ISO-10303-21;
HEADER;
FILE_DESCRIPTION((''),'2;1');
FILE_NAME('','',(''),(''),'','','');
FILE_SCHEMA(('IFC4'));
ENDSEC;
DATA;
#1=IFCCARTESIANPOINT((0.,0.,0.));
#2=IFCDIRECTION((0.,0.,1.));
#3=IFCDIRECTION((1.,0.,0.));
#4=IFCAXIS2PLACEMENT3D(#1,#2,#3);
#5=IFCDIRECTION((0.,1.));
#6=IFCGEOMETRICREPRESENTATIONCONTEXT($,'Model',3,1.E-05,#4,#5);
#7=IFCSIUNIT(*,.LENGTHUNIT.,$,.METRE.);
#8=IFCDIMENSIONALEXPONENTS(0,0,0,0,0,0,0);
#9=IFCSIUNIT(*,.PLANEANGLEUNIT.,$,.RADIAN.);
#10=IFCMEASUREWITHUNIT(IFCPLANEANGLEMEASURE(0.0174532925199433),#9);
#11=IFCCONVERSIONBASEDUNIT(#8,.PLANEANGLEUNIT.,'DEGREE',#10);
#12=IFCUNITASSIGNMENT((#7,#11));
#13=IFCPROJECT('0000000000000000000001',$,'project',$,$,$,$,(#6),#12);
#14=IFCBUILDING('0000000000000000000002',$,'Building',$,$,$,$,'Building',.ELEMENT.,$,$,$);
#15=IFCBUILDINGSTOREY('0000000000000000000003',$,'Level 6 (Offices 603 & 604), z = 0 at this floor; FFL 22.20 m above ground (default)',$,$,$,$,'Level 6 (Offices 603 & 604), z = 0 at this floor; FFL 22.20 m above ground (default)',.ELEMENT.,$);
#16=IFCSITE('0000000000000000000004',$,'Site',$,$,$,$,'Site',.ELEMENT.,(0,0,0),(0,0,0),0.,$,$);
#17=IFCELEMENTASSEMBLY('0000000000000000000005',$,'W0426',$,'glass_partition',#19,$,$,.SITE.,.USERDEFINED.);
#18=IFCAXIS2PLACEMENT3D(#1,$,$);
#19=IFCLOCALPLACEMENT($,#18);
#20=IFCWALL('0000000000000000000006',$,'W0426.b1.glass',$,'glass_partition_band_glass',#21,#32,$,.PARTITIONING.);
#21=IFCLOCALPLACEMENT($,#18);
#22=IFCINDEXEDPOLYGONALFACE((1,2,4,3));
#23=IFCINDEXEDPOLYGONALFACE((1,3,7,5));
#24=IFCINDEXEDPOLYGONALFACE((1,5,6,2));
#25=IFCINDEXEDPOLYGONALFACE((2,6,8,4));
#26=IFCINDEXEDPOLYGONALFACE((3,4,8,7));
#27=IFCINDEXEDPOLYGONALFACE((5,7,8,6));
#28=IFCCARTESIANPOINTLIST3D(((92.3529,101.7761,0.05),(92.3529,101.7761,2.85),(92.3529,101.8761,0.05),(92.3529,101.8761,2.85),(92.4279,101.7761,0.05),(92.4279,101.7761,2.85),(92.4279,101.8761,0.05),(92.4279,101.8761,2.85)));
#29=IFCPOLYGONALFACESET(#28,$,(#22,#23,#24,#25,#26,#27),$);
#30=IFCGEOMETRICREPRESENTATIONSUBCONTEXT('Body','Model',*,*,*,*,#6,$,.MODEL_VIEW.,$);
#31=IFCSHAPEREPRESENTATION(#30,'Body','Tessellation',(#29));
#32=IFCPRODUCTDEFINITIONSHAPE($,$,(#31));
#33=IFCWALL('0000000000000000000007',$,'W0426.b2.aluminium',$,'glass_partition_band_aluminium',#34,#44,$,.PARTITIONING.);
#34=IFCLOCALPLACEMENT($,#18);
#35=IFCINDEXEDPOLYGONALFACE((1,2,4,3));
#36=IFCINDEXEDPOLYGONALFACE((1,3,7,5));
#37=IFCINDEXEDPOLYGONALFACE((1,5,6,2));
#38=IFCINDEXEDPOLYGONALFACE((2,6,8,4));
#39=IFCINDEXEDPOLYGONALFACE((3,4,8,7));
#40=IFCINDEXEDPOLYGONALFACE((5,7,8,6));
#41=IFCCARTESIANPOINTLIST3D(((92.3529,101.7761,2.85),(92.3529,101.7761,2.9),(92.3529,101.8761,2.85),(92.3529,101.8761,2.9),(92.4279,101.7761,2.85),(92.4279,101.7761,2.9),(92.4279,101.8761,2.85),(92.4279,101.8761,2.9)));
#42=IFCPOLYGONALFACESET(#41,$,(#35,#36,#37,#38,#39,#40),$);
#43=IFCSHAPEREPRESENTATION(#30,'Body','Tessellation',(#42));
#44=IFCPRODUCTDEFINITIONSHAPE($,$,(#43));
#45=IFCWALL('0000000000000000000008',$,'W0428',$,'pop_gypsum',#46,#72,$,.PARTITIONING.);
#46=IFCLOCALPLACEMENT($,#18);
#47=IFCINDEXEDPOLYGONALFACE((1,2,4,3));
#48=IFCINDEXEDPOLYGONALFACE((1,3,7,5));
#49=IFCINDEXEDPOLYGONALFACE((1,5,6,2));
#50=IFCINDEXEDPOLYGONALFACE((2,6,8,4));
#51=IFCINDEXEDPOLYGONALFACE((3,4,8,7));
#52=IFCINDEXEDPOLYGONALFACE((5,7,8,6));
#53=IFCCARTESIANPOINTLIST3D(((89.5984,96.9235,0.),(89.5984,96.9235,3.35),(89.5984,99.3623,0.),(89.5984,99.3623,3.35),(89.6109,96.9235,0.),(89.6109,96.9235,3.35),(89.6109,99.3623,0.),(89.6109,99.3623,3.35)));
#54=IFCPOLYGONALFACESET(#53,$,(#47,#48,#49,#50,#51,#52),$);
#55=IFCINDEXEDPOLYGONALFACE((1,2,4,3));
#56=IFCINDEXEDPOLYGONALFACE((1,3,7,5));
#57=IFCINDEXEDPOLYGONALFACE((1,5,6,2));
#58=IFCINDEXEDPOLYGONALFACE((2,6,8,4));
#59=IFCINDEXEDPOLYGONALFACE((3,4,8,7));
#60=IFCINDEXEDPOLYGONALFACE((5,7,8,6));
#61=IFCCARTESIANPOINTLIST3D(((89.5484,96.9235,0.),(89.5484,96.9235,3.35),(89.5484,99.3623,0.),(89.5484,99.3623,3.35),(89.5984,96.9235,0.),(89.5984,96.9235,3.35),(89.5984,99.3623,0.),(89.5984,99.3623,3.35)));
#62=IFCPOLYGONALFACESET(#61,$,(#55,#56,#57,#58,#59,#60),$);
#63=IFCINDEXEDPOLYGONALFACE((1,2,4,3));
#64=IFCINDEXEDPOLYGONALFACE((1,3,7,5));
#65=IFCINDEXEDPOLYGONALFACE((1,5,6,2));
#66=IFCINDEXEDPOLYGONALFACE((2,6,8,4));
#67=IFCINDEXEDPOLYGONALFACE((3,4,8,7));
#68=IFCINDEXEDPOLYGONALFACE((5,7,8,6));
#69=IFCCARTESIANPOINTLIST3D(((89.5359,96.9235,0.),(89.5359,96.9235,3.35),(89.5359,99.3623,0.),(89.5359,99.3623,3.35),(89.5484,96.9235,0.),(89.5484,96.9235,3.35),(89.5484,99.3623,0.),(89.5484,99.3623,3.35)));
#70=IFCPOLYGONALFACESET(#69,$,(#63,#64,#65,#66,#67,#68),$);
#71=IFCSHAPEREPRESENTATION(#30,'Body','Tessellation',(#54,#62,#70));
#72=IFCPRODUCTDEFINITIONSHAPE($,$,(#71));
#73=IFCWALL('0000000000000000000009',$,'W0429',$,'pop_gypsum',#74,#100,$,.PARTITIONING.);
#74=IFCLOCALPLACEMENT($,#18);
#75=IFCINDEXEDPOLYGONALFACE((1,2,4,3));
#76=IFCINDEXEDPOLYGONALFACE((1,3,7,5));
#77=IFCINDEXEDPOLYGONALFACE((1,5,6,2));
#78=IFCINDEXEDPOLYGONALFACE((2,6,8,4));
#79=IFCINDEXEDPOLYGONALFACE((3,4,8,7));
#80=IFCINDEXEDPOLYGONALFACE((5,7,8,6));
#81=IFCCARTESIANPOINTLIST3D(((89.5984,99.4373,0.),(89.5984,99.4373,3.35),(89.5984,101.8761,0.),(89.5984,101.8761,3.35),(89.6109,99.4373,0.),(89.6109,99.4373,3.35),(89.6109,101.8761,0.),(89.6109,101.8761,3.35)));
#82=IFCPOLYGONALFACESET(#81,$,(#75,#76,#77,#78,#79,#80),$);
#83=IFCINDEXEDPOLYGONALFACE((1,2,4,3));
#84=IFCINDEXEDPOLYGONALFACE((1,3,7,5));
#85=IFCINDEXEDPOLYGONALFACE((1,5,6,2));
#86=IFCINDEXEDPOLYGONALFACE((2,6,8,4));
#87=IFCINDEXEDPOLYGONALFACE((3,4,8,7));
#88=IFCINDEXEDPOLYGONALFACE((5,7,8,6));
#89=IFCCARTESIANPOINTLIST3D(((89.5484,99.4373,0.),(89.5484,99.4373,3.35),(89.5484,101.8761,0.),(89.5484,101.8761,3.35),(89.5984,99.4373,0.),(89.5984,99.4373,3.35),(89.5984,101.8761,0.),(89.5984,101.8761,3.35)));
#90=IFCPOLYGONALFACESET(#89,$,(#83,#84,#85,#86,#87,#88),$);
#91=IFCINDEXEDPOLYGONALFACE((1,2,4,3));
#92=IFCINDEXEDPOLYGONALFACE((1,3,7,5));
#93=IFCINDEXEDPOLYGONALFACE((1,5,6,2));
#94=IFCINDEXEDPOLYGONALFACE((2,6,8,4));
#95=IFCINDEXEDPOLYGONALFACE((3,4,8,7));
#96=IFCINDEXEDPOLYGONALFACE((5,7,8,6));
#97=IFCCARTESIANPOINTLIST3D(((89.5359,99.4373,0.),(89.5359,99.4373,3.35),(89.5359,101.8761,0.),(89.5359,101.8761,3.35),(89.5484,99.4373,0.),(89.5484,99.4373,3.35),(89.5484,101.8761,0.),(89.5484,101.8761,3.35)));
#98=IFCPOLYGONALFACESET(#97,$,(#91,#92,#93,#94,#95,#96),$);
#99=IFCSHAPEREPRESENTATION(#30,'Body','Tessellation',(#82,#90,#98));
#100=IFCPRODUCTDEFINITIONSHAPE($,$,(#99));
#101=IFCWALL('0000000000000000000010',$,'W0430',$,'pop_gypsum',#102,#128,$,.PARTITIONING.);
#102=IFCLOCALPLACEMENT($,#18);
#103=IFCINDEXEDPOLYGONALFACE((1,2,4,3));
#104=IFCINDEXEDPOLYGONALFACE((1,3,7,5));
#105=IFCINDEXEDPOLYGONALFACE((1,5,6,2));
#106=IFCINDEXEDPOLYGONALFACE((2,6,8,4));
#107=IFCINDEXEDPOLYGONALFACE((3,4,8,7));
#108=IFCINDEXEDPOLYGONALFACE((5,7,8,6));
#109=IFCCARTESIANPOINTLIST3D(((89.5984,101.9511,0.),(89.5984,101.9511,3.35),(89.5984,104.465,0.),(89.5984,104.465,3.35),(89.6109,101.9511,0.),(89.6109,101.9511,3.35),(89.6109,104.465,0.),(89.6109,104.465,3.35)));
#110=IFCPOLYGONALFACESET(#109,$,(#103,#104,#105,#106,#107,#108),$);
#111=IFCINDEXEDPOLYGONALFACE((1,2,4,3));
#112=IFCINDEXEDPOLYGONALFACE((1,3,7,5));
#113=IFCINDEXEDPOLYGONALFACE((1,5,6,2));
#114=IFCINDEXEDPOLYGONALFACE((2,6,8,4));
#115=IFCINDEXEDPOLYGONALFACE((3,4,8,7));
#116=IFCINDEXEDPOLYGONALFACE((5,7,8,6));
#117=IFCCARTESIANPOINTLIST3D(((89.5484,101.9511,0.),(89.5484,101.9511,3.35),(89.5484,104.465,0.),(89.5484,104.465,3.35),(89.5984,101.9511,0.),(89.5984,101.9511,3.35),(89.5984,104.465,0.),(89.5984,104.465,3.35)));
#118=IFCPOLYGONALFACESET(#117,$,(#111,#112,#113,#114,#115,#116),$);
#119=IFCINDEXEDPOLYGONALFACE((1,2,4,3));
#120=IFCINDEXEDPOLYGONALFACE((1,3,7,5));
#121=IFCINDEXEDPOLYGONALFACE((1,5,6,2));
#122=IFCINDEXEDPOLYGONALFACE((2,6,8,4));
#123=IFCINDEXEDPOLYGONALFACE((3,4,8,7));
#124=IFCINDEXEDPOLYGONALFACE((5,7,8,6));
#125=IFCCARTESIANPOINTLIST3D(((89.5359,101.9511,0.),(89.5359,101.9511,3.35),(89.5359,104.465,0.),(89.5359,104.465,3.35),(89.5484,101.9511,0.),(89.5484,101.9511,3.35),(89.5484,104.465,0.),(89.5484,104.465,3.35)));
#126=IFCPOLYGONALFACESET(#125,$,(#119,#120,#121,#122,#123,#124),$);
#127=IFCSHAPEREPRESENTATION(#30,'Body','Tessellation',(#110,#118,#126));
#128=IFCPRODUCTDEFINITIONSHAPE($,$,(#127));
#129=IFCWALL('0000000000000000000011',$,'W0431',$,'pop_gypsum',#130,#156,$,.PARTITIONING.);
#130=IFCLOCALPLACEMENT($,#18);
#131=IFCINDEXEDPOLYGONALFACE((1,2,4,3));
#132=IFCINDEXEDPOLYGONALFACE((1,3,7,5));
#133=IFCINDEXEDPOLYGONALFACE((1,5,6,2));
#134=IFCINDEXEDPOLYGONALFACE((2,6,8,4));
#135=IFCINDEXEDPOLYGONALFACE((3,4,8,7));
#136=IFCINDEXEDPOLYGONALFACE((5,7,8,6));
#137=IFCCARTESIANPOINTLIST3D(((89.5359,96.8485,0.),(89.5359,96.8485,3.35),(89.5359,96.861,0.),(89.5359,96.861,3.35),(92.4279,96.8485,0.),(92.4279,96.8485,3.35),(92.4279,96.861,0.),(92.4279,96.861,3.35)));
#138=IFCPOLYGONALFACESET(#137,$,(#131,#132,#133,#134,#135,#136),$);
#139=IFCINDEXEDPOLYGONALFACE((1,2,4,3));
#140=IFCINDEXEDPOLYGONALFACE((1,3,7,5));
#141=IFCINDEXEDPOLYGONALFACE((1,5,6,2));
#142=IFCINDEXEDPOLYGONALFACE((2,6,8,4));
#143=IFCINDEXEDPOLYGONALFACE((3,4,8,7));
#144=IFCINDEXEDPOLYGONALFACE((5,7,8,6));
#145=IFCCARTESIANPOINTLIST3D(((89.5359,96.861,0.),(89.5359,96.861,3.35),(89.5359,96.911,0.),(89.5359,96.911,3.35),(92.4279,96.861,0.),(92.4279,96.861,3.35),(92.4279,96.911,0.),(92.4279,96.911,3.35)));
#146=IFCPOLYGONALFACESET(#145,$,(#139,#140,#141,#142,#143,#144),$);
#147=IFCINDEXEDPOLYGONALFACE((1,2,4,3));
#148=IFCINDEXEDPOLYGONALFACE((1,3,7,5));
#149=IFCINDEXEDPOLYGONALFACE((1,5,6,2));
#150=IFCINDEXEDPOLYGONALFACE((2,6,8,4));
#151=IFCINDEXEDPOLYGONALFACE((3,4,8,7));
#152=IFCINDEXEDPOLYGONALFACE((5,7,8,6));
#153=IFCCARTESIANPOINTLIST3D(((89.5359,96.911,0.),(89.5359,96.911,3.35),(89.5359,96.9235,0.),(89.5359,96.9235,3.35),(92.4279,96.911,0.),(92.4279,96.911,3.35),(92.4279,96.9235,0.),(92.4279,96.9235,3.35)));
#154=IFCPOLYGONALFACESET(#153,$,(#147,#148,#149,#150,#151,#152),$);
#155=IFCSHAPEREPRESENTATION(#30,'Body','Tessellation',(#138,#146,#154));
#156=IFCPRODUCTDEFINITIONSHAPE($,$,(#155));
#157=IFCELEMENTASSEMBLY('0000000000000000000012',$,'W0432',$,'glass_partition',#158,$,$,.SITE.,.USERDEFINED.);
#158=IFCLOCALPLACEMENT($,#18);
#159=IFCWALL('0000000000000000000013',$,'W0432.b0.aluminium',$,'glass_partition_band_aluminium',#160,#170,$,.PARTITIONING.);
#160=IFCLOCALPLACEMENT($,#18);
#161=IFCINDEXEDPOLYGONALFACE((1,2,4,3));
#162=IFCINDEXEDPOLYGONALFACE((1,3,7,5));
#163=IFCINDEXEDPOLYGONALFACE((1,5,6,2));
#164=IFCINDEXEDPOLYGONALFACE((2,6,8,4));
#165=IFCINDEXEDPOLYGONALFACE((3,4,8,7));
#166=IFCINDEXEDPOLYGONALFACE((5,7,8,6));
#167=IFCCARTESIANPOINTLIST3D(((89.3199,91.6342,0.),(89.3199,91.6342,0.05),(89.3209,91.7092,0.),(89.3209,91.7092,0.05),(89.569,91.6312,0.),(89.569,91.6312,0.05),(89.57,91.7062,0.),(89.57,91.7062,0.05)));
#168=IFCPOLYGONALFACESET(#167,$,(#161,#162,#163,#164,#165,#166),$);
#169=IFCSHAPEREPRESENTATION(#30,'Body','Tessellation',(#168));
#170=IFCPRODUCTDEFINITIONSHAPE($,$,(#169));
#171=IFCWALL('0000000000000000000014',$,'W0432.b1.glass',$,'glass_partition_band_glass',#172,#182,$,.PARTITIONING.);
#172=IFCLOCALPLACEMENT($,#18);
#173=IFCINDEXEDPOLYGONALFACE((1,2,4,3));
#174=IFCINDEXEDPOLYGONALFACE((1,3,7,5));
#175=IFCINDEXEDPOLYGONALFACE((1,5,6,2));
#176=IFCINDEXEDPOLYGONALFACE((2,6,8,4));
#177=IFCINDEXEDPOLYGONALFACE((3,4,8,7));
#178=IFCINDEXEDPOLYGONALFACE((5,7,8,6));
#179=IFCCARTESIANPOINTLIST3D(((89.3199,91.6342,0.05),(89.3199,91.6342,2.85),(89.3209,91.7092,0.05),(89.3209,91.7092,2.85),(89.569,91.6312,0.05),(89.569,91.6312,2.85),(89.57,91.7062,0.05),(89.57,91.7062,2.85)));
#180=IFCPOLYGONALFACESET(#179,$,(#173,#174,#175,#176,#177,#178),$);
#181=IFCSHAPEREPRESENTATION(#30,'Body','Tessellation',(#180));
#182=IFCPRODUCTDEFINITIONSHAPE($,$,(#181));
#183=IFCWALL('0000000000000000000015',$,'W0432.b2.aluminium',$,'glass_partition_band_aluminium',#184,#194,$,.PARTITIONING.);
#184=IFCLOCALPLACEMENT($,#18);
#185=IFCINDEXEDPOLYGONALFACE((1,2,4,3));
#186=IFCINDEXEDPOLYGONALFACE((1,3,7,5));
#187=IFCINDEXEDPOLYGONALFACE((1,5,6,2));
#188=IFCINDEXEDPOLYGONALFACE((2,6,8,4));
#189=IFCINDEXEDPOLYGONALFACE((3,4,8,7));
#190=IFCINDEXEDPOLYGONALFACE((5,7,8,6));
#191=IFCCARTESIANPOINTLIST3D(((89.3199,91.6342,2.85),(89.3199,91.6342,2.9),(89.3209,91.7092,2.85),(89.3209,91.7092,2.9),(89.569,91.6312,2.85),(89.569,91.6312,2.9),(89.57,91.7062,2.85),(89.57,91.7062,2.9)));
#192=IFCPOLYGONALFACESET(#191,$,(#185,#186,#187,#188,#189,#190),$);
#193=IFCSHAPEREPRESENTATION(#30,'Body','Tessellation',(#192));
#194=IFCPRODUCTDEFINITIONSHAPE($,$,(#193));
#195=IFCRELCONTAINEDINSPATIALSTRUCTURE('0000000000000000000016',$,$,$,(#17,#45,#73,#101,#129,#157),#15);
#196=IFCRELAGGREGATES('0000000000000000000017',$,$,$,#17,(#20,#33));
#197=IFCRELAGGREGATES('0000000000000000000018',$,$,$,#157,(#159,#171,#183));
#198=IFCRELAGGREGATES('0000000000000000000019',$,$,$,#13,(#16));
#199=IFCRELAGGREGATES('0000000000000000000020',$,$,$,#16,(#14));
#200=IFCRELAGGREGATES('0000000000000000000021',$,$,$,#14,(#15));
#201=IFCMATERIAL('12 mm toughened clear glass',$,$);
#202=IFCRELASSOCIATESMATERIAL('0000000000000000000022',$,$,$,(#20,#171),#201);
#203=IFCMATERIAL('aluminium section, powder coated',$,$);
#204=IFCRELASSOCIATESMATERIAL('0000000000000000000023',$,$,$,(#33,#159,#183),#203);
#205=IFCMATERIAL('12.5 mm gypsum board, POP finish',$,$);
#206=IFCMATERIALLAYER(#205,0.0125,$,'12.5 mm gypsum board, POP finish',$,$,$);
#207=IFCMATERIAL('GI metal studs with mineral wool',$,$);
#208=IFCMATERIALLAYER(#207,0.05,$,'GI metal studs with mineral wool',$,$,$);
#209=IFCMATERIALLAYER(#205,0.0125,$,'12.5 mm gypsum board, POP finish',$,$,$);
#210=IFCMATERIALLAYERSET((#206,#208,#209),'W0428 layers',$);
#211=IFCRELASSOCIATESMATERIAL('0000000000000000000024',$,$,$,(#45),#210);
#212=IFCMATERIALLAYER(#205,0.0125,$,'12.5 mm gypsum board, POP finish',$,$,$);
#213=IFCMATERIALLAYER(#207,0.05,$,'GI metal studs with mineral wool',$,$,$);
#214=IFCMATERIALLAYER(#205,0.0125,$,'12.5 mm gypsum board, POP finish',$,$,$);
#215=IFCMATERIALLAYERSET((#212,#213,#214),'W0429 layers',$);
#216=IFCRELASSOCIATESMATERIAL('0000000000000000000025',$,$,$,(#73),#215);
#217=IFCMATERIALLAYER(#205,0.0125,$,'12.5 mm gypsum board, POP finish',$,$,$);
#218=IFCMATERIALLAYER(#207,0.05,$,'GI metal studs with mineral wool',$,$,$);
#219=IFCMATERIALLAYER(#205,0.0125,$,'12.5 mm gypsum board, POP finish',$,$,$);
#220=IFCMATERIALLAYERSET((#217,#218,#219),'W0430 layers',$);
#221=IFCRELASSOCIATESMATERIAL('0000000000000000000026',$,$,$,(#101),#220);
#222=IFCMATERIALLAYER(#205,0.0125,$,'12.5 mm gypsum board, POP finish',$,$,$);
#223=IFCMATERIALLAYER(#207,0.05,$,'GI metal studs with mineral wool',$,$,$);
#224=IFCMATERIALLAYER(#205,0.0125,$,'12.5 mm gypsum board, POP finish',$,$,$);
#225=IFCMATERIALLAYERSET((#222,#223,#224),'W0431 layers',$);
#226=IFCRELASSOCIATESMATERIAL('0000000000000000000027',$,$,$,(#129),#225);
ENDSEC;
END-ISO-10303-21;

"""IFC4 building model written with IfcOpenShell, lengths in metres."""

from ifc_helpers import new_model, entity, si_unit, converted_unit, direction, frame, frame_2d, origin_with_axes, place, context, subcontext, project, spatial, rectangle, extrude, material, layer, layer_set, layer_usage, element, aggregate, save


model = new_model("IFC4")

# Units and contexts
model_context = context("Model", 3, precision=1e-05, world=origin_with_axes(), true_north=direction((0.0, 1.0)))
body_context = subcontext(model_context, "Body", "Model", "MODEL_VIEW")
ifc_project = project(units=[si_unit("LENGTHUNIT", "METRE"), converted_unit("PLANEANGLEUNIT", "DEGREE", entity("IfcPlaneAngleMeasure", 0.0174532925199433), si_unit("PLANEANGLEUNIT", "RADIAN"), dimensions=[0, 0, 0, 0, 0, 0, 0])], contexts=[model_context])

# Site, building, storey
site = spatial("IfcSite", under=ifc_project, Name="Site", LongName="Site", CompositionType="ELEMENT", RefLatitude=(0, 0, 0), RefLongitude=(0, 0, 0), RefElevation=0.0)
building = spatial("IfcBuilding", under=site, Name="Building", LongName="Building", CompositionType="ELEMENT")
storey = spatial("IfcBuildingStorey", under=building, Name="Level 6 (Offices 603 & 604), z = 0 at this floor; FFL 22.20 m above ground (default)", LongName="Level 6 (Offices 603 & 604), z = 0 at this floor; FFL 22.20 m above ground (default)", CompositionType="ELEMENT")

# Shared definitions
ifc_material_1 = material(Name="aluminium section, powder coated")
placement = place(None, origin_with_axes())

# Shared definitions
ifc_material_2 = material(Name="12.5 mm gypsum board, POP finish")
ifc_material_3 = material(Name="GI metal studs with mineral wool")

# Element assembly, walls
ifc_material_4 = material(Name="12 mm toughened clear glass")
assembly_1 = element("IfcElementAssembly", 1, inside=storey, Name="W0426", ObjectType="glass_partition", AssemblyPlace="SITE", PredefinedType="USERDEFINED")
wall_1 = element("IfcWall", 2, at=placement, material=ifc_material_4, Name="W0426.b1.glass", ObjectType="glass_partition_band_glass", PredefinedType="PARTITIONING", context=body_context, shape_type="SweptSolid", body=[
    extrude(rectangle(XDim=0.1, YDim=0.075, at=frame_2d((0.0, 0.0), x_axis=(0.0, 1.0))), frame((92.3904, 101.8261, 0.05), z_axis=(0.0, 0.0, 1.0), x_axis=(1.0, 0.0, 0.0)), (0.0, 0.0, 1.0), 2.8),
])
wall_2 = element("IfcWall", 3, at=placement, material=ifc_material_1, Name="W0426.b2.aluminium", ObjectType="glass_partition_band_aluminium", PredefinedType="PARTITIONING", context=body_context, shape_type="SweptSolid", body=[
    extrude(rectangle(XDim=0.1, YDim=0.075, at=frame_2d((0.0, 0.0), x_axis=(0.0, 1.0))), frame((92.3904, 101.8261, 2.85), z_axis=(0.0, 0.0, 1.0), x_axis=(1.0, 0.0, 0.0)), (0.0, 0.0, 1.0), 0.05),
])
aggregate(assembly_1, [wall_1, wall_2])

# Walls
ifc_layer_1 = layer(ifc_material_2, 0.0125, Name="12.5 mm gypsum board, POP finish")
ifc_layer_2 = layer(ifc_material_3, 0.05, Name="GI metal studs with mineral wool")
ifc_layer_3 = layer(ifc_material_2, 0.0125, Name="12.5 mm gypsum board, POP finish")
ifc_layer_set_1 = layer_set([ifc_layer_1, ifc_layer_2, ifc_layer_3], Name="W0428 layers")
ifc_layer_usage_1 = layer_usage(ifc_layer_set_1, "AXIS2", "POSITIVE", -0.0375)
element("IfcWall", 4, at=placement, inside=storey, material=ifc_layer_usage_1, Name="W0428", ObjectType="pop_gypsum", PredefinedType="PARTITIONING", context=body_context, shape_type="SweptSolid", body=[
    extrude(rectangle(XDim=2.4388, YDim=0.0125, at=frame_2d((0.0, 0.0), x_axis=(0.0, 1.0))), frame((89.6047, 98.1429, 0.0), z_axis=(0.0, 0.0, 1.0), x_axis=(1.0, 0.0, 0.0)), (0.0, 0.0, 1.0), 3.35),
    extrude(rectangle(XDim=2.4388, YDim=0.05, at=frame_2d((-0.0312, 0.0), x_axis=(0.0, 1.0))), frame((89.6047, 98.1429, 0.0), z_axis=(0.0, 0.0, 1.0), x_axis=(1.0, 0.0, 0.0)), (0.0, 0.0, 1.0), 3.35),
    extrude(rectangle(XDim=2.4388, YDim=0.0125, at=frame_2d((-0.0625, 0.0), x_axis=(0.0, 1.0))), frame((89.6047, 98.1429, 0.0), z_axis=(0.0, 0.0, 1.0), x_axis=(1.0, 0.0, 0.0)), (0.0, 0.0, 1.0), 3.35),
])
ifc_layer_4 = layer(ifc_material_2, 0.0125, Name="12.5 mm gypsum board, POP finish")
ifc_layer_5 = layer(ifc_material_3, 0.05, Name="GI metal studs with mineral wool")
ifc_layer_6 = layer(ifc_material_2, 0.0125, Name="12.5 mm gypsum board, POP finish")
ifc_layer_set_2 = layer_set([ifc_layer_4, ifc_layer_5, ifc_layer_6], Name="W0429 layers")
ifc_layer_usage_2 = layer_usage(ifc_layer_set_2, "AXIS2", "POSITIVE", -0.0375)
element("IfcWall", 5, at=placement, inside=storey, material=ifc_layer_usage_2, Name="W0429", ObjectType="pop_gypsum", PredefinedType="PARTITIONING", context=body_context, shape_type="SweptSolid", body=[
    extrude(rectangle(XDim=2.4388, YDim=0.0125, at=frame_2d((0.0, 0.0), x_axis=(0.0, 1.0))), frame((89.6047, 100.6567, 0.0), z_axis=(0.0, 0.0, 1.0), x_axis=(1.0, 0.0, 0.0)), (0.0, 0.0, 1.0), 3.35),
    extrude(rectangle(XDim=2.4388, YDim=0.05, at=frame_2d((-0.0312, 0.0), x_axis=(0.0, 1.0))), frame((89.6047, 100.6567, 0.0), z_axis=(0.0, 0.0, 1.0), x_axis=(1.0, 0.0, 0.0)), (0.0, 0.0, 1.0), 3.35),
    extrude(rectangle(XDim=2.4388, YDim=0.0125, at=frame_2d((-0.0625, 0.0), x_axis=(0.0, 1.0))), frame((89.6047, 100.6567, 0.0), z_axis=(0.0, 0.0, 1.0), x_axis=(1.0, 0.0, 0.0)), (0.0, 0.0, 1.0), 3.35),
])
ifc_layer_7 = layer(ifc_material_2, 0.0125, Name="12.5 mm gypsum board, POP finish")
ifc_layer_8 = layer(ifc_material_3, 0.05, Name="GI metal studs with mineral wool")
ifc_layer_9 = layer(ifc_material_2, 0.0125, Name="12.5 mm gypsum board, POP finish")
ifc_layer_set_3 = layer_set([ifc_layer_7, ifc_layer_8, ifc_layer_9], Name="W0430 layers")
ifc_layer_usage_3 = layer_usage(ifc_layer_set_3, "AXIS2", "POSITIVE", -0.0375)
element("IfcWall", 6, at=placement, inside=storey, material=ifc_layer_usage_3, Name="W0430", ObjectType="pop_gypsum", PredefinedType="PARTITIONING", context=body_context, shape_type="SweptSolid", body=[
    extrude(rectangle(XDim=2.5139, YDim=0.0125, at=frame_2d((0.0, 0.0), x_axis=(0.0, 1.0))), frame((89.6047, 103.2081, 0.0), z_axis=(0.0, 0.0, 1.0), x_axis=(1.0, 0.0, 0.0)), (0.0, 0.0, 1.0), 3.35),
    extrude(rectangle(XDim=2.5139, YDim=0.05, at=frame_2d((-0.0312, 0.0), x_axis=(0.0, 1.0))), frame((89.6047, 103.2081, 0.0), z_axis=(0.0, 0.0, 1.0), x_axis=(1.0, 0.0, 0.0)), (0.0, 0.0, 1.0), 3.35),
    extrude(rectangle(XDim=2.5139, YDim=0.0125, at=frame_2d((-0.0625, 0.0), x_axis=(0.0, 1.0))), frame((89.6047, 103.2081, 0.0), z_axis=(0.0, 0.0, 1.0), x_axis=(1.0, 0.0, 0.0)), (0.0, 0.0, 1.0), 3.35),
])
ifc_layer_10 = layer(ifc_material_2, 0.0125, Name="12.5 mm gypsum board, POP finish")
ifc_layer_11 = layer(ifc_material_3, 0.05, Name="GI metal studs with mineral wool")
ifc_layer_12 = layer(ifc_material_2, 0.0125, Name="12.5 mm gypsum board, POP finish")
ifc_layer_set_4 = layer_set([ifc_layer_10, ifc_layer_11, ifc_layer_12], Name="W0431 layers")
ifc_layer_usage_4 = layer_usage(ifc_layer_set_4, "AXIS2", "POSITIVE", -0.0375)
element("IfcWall", 7, at=placement, inside=storey, material=ifc_layer_usage_4, Name="W0431", ObjectType="pop_gypsum", PredefinedType="PARTITIONING", context=body_context, shape_type="SweptSolid", body=[
    extrude(rectangle(XDim=2.892, YDim=0.0125, at=frame_2d((0.0, 0.0), x_axis=(1.0, 0.0))), frame((90.9819, 96.8547, 0.0), z_axis=(0.0, 0.0, 1.0), x_axis=(1.0, 0.0, 0.0)), (0.0, 0.0, 1.0), 3.35),
    extrude(rectangle(XDim=2.892, YDim=0.05, at=frame_2d((0.0, 0.0313), x_axis=(1.0, 0.0))), frame((90.9819, 96.8547, 0.0), z_axis=(0.0, 0.0, 1.0), x_axis=(1.0, 0.0, 0.0)), (0.0, 0.0, 1.0), 3.35),
    extrude(rectangle(XDim=2.892, YDim=0.0125, at=frame_2d((0.0, 0.0625), x_axis=(1.0, 0.0))), frame((90.9819, 96.8547, 0.0), z_axis=(0.0, 0.0, 1.0), x_axis=(1.0, 0.0, 0.0)), (0.0, 0.0, 1.0), 3.35),
])

# Element assembly, walls
assembly_2 = element("IfcElementAssembly", 8, inside=storey, Name="W0432", ObjectType="glass_partition", AssemblyPlace="SITE", PredefinedType="USERDEFINED")
wall_3 = element("IfcWall", 9, at=placement, material=ifc_material_1, Name="W0432.b0.aluminium", ObjectType="glass_partition_band_aluminium", PredefinedType="PARTITIONING", context=body_context, shape_type="SweptSolid", body=[
    extrude(rectangle(XDim=0.2491, YDim=0.075, at=frame_2d((0.0, 0.0), x_axis=(0.999927, -0.012042))), frame((89.445, 91.6702, 0.0), z_axis=(0.0, 0.0, 1.0), x_axis=(1.0, 0.0, 0.0)), (0.0, 0.0, 1.0), 0.05),
])
wall_4 = element("IfcWall", 10, at=placement, material=ifc_material_4, Name="W0432.b1.glass", ObjectType="glass_partition_band_glass", PredefinedType="PARTITIONING", context=body_context, shape_type="SweptSolid", body=[
    extrude(rectangle(XDim=0.2491, YDim=0.075, at=frame_2d((0.0, 0.0), x_axis=(0.999927, -0.012042))), frame((89.445, 91.6702, 0.05), z_axis=(0.0, 0.0, 1.0), x_axis=(1.0, 0.0, 0.0)), (0.0, 0.0, 1.0), 2.8),
])
wall_5 = element("IfcWall", 11, at=placement, material=ifc_material_1, Name="W0432.b2.aluminium", ObjectType="glass_partition_band_aluminium", PredefinedType="PARTITIONING", context=body_context, shape_type="SweptSolid", body=[
    extrude(rectangle(XDim=0.2491, YDim=0.075, at=frame_2d((0.0, 0.0), x_axis=(0.999927, -0.012042))), frame((89.445, 91.6702, 2.85), z_axis=(0.0, 0.0, 1.0), x_axis=(1.0, 0.0, 0.0)), (0.0, 0.0, 1.0), 0.05),
])
aggregate(assembly_2, [wall_3, wall_4, wall_5])

save(model, "model.ifc")
